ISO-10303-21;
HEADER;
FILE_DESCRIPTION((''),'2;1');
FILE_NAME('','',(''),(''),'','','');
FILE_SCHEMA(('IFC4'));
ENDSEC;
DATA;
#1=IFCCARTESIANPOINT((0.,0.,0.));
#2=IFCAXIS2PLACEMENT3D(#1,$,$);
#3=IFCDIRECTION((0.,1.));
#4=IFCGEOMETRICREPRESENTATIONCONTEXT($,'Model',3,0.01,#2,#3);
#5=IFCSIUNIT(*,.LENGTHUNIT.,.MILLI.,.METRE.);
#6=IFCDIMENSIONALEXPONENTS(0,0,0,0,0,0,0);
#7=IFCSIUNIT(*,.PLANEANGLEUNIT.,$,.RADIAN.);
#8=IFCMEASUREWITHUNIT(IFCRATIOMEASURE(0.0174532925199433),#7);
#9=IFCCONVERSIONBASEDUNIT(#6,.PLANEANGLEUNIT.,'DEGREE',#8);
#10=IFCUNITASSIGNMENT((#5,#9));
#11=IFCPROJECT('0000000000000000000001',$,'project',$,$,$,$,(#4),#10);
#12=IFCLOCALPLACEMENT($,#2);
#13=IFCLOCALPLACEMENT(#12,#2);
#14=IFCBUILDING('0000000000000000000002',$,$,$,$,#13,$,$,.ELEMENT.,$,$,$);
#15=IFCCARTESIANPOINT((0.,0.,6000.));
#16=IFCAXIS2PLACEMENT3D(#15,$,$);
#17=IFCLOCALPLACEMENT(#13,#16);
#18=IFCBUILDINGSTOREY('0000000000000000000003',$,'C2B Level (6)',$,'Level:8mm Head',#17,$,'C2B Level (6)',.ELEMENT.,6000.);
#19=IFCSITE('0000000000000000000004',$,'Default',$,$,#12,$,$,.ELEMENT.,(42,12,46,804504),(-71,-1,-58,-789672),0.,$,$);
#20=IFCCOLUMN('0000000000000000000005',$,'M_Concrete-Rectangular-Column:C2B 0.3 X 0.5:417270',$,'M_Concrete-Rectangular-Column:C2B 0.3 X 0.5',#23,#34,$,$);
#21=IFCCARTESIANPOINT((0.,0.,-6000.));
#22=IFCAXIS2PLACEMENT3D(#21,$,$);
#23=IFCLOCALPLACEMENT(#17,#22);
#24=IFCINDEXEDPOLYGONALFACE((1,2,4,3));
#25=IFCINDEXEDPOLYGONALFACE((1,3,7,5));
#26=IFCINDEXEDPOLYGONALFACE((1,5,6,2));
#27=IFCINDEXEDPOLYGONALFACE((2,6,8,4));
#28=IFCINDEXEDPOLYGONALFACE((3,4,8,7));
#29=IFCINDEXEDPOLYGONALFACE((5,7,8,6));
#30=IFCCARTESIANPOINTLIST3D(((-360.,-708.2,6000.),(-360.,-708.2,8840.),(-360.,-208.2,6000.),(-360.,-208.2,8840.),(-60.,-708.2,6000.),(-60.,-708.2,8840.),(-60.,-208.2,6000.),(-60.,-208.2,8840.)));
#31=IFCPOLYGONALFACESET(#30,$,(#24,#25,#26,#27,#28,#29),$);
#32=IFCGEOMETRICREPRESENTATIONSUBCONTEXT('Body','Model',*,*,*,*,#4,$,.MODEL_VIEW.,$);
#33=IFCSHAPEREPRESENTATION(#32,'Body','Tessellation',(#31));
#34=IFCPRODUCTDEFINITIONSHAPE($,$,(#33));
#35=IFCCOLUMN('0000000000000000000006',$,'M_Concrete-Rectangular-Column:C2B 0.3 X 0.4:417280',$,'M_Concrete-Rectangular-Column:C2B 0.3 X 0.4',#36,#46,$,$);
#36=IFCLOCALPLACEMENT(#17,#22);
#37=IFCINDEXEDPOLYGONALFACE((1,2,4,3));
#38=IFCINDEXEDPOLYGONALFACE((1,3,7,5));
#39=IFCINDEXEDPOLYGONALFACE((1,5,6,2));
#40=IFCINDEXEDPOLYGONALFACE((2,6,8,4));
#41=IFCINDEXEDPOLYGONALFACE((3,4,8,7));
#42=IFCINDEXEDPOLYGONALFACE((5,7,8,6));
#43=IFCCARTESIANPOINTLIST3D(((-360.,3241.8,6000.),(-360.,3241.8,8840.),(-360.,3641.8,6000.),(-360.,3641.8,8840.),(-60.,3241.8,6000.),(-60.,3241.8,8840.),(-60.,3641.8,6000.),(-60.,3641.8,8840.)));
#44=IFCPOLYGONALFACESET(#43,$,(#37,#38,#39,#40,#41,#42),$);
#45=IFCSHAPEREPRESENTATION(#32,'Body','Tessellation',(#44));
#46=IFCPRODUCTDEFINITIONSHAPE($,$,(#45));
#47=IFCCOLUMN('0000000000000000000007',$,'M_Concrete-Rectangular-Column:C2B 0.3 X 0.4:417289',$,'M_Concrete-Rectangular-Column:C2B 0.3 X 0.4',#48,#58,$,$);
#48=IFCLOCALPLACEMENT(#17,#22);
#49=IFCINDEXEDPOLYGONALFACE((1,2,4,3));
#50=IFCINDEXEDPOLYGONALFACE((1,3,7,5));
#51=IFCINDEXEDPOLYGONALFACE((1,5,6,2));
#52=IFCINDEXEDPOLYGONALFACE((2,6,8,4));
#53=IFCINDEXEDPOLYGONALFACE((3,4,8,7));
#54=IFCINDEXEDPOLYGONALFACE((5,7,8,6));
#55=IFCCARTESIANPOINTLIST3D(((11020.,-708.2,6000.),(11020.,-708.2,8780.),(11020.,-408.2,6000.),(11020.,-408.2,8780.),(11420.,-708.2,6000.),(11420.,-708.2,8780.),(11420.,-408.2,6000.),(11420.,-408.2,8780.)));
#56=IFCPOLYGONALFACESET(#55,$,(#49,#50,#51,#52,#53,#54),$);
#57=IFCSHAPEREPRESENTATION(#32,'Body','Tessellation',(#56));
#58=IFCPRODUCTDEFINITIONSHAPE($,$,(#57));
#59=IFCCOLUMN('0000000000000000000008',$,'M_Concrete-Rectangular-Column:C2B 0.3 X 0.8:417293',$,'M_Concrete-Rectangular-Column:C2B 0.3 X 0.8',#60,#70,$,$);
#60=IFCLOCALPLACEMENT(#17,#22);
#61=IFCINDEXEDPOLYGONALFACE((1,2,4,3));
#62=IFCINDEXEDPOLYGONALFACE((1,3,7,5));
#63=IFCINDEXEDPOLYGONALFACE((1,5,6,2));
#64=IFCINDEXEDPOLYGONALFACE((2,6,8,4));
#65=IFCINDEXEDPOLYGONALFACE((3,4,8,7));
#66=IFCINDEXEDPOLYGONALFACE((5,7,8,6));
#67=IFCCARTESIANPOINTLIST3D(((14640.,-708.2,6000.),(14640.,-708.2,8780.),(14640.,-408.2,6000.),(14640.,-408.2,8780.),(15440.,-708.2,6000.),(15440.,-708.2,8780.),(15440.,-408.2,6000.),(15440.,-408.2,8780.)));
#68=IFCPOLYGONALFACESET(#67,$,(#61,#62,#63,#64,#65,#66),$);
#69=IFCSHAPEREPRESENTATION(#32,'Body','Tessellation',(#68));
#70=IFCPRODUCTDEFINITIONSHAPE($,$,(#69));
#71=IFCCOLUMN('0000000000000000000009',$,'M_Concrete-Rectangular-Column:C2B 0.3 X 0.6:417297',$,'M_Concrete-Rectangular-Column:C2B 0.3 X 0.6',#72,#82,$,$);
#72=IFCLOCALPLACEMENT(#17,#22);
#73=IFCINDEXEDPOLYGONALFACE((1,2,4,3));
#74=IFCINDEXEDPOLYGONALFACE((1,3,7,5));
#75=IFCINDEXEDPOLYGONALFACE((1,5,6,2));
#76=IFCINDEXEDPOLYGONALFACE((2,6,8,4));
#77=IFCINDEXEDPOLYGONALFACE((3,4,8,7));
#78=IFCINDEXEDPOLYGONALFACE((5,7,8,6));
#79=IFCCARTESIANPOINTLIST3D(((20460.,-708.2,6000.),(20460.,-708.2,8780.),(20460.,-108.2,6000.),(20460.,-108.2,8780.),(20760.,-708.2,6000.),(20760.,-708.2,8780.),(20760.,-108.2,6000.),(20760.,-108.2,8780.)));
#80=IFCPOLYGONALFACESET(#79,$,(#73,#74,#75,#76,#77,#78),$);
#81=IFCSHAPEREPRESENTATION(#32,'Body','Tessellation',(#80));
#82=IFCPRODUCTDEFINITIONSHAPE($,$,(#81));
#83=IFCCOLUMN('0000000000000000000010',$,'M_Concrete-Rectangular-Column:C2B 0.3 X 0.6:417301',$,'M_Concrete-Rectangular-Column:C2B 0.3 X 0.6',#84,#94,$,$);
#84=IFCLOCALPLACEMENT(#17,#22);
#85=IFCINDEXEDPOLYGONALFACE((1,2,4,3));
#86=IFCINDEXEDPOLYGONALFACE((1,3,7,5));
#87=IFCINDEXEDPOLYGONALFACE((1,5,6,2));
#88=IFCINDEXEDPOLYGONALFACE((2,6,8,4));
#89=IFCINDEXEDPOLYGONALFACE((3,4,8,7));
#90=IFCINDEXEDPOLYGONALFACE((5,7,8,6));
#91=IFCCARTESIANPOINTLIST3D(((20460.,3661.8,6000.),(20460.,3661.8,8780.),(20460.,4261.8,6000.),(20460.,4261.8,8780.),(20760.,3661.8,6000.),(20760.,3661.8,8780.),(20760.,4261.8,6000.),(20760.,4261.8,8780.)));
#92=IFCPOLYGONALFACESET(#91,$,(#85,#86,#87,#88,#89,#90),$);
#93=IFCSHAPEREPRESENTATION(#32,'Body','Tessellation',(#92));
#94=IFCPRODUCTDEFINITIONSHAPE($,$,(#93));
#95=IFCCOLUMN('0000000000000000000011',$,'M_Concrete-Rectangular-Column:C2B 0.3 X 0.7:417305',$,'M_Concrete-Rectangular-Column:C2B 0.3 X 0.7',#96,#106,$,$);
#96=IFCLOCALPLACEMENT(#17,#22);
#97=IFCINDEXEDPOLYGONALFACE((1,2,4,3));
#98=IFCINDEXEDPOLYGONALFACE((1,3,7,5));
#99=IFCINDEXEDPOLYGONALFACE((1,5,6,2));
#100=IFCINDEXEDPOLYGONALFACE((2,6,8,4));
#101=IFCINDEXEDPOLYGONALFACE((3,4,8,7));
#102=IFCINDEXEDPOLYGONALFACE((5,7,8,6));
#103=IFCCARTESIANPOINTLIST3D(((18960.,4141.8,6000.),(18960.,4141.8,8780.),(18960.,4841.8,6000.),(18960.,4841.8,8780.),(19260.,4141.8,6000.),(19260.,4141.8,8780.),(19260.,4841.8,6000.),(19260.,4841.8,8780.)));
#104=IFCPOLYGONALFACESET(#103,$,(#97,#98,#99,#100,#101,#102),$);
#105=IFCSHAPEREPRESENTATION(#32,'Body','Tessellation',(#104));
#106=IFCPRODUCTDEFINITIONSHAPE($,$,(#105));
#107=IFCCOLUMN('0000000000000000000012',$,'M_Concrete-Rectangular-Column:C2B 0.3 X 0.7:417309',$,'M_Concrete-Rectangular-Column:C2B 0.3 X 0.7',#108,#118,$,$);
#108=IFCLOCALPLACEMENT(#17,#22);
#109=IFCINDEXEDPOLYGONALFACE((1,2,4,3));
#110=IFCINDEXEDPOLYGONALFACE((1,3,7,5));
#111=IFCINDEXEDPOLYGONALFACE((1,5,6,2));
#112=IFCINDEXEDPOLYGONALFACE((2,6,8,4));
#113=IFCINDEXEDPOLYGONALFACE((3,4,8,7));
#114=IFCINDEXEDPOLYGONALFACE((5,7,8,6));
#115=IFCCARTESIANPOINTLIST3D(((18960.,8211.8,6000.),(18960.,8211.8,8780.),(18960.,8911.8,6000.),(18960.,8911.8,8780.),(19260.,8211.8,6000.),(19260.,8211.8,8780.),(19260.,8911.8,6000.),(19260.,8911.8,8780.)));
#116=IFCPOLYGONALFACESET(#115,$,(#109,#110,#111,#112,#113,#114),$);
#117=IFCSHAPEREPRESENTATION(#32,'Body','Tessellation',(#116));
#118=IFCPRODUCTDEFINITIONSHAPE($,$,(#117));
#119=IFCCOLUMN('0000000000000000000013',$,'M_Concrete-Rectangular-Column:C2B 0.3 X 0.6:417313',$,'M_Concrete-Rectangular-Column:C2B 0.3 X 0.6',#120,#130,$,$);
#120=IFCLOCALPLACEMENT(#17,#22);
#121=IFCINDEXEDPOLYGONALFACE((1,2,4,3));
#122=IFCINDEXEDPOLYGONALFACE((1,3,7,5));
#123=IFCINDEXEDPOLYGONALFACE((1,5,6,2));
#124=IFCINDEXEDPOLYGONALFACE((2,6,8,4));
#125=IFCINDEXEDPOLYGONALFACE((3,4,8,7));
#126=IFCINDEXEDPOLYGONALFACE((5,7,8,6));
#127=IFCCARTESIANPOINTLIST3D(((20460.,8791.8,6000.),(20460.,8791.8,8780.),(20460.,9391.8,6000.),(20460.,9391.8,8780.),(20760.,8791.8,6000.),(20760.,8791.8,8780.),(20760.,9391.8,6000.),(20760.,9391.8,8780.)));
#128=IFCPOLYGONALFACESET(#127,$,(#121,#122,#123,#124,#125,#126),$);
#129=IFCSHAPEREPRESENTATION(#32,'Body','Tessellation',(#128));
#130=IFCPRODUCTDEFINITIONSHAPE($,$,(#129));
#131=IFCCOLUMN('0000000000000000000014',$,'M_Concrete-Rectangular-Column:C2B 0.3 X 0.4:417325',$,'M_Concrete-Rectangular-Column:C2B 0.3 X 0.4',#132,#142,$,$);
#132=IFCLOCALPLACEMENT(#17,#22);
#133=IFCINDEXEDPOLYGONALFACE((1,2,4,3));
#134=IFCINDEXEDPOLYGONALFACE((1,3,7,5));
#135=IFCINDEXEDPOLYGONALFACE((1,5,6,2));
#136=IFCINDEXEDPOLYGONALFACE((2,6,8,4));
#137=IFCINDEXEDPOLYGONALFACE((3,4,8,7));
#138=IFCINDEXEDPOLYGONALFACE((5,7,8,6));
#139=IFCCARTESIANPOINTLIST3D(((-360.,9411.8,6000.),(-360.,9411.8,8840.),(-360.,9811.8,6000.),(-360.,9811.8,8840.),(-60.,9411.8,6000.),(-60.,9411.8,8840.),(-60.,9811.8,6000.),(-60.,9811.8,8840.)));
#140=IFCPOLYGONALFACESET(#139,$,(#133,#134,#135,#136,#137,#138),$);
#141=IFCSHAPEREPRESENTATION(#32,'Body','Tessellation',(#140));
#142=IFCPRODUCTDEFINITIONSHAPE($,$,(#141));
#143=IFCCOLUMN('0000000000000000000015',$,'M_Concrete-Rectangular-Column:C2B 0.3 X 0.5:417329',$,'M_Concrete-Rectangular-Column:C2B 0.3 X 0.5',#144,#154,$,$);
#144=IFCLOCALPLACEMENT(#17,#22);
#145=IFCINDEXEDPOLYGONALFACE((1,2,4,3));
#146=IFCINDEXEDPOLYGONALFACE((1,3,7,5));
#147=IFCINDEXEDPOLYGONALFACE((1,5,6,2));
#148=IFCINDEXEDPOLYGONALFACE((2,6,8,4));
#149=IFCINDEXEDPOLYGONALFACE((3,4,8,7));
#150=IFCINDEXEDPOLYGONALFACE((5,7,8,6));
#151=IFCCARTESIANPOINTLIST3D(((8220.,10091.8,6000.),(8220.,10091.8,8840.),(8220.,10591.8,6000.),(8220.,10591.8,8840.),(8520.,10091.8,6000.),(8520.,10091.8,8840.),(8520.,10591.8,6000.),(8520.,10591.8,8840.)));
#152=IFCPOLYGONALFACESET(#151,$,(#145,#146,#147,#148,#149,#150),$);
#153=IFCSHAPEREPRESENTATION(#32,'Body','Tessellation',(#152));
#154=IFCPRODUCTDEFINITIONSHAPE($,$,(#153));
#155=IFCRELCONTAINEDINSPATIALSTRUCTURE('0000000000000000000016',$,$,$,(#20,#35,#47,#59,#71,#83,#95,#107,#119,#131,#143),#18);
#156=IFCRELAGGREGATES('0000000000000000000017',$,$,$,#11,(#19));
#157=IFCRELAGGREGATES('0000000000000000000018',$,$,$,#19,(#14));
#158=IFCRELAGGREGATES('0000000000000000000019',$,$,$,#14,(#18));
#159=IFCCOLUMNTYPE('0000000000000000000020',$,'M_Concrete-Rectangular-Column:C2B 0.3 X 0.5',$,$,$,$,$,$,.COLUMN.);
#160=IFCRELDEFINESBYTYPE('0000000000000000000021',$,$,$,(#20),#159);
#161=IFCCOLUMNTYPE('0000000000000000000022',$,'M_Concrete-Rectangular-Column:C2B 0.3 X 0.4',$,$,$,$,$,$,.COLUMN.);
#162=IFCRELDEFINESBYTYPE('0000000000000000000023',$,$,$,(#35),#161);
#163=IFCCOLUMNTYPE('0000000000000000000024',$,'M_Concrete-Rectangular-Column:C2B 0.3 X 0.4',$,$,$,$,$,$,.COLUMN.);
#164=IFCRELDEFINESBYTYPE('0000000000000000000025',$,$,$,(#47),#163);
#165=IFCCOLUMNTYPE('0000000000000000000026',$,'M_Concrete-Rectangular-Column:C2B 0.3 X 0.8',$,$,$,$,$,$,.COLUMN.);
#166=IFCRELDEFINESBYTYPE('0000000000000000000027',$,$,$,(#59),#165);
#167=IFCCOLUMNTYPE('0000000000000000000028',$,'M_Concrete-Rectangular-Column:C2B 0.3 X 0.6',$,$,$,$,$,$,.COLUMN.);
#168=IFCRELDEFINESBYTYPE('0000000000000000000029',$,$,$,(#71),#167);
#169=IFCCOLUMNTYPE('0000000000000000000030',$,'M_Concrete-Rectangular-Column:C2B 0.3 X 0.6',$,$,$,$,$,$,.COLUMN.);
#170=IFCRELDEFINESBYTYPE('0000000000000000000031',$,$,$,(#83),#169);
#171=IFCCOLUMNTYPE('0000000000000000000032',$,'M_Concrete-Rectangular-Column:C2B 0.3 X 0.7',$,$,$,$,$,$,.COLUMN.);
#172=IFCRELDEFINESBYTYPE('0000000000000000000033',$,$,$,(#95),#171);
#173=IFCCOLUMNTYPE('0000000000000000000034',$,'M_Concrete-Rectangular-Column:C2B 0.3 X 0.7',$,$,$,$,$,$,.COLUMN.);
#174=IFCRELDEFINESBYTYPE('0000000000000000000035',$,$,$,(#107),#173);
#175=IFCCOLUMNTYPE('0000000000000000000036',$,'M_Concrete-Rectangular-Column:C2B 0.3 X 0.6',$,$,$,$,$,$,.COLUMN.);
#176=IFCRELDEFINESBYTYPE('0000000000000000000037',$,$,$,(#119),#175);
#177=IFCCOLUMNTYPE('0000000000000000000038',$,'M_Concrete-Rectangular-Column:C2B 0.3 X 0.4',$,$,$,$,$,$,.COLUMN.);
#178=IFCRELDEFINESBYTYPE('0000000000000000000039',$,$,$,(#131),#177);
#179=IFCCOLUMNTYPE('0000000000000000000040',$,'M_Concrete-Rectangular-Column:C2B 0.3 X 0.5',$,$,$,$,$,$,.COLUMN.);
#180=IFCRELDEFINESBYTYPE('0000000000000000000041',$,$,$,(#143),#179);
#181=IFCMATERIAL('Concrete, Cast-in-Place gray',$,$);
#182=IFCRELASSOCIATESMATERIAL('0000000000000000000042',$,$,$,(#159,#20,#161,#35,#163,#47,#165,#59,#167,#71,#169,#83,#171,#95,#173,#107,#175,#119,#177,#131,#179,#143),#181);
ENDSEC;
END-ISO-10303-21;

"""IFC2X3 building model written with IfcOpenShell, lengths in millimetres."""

from ifc_helpers import new_model, entity, si_unit, converted_unit, direction, frame, frame_2d, origin, origin_2d_with_axis, place, context, subcontext, project, spatial, rectangle, extrude, source, transform, mapped, material, type_object, type_shapes, element, save


model = new_model("IFC2X3")

# Units and contexts
model_context = context("Model", 3, precision=0.01, world=origin(), true_north=direction((0.0, 1.0)))
body_context = subcontext(model_context, "Body", "Model", "MODEL_VIEW")
ifc_project = project(units=[si_unit("LENGTHUNIT", "METRE", prefix="MILLI"), converted_unit("PLANEANGLEUNIT", "DEGREE", entity("IfcRatioMeasure", 0.0174532925199433), si_unit("PLANEANGLEUNIT", "RADIAN"), dimensions=[0, 0, 0, 0, 0, 0, 0])], contexts=[model_context])

# Site, building, storey
site_placement = place(None, origin())
site = spatial("IfcSite", under=ifc_project, at=site_placement, Name="Default", CompositionType="ELEMENT", RefLatitude=(42, 12, 46, 804504), RefLongitude=(-71, -1, -58, -789672), RefElevation=0.0)
building_placement = place(site_placement, origin())
building = spatial("IfcBuilding", under=site, at=building_placement, CompositionType="ELEMENT")
storey_placement = place(building_placement, frame((0.0, 0.0, 6000.0)))
storey = spatial("IfcBuildingStorey", under=building, at=storey_placement, Name="C2B Level (6)", ObjectType="Level:8mm Head", LongName="C2B Level (6)", CompositionType="ELEMENT", Elevation=6000.0)

# Columns
ifc_material = material(Name="Concrete, Cast-in-Place gray")
column_type_1 = type_object("IfcColumnType", Name="M_Concrete-Rectangular-Column:C2B 0.3 X 0.5", PredefinedType="COLUMN", material=ifc_material)
shared_shape_1 = source(origin(), body_context, "Body", "SweptSolid", [
    extrude(rectangle(XDim=500.0, YDim=300.0, at=frame_2d((0.0, 0.0), x_axis=(1.0, 0.0))), frame((-210.0, -458.2, 6000.0), z_axis=(0.0, 0.0, 1.0), x_axis=(0.0, -1.0, 0.0)), (0.0, 0.0, 1.0), 2840.0),
])
type_shapes(column_type_1, [shared_shape_1])
column_1_placement = place(storey_placement, frame((0.0, 0.0, -6000.0)))
element("IfcColumn", 1, at=column_1_placement, inside=storey, type_object=column_type_1, material=ifc_material, Name="M_Concrete-Rectangular-Column:C2B 0.3 X 0.5:417270", ObjectType="M_Concrete-Rectangular-Column:C2B 0.3 X 0.5", context=body_context, shape_type="MappedRepresentation", body=[
    mapped(shared_shape_1, transform((0.0, 0.0, 0.0), scale=1.0)),
])
column_type_2 = type_object("IfcColumnType", Name="M_Concrete-Rectangular-Column:C2B 0.3 X 0.4", PredefinedType="COLUMN", material=ifc_material)
shared_shape_2 = source(origin(), body_context, "Body", "SweptSolid", [
    extrude(rectangle(XDim=400.0, YDim=300.0, at=frame_2d((0.0, 0.0), x_axis=(1.0, 0.0))), frame((-210.0, 3441.8, 6000.0), z_axis=(0.0, 0.0, 1.0), x_axis=(0.0, -1.0, 0.0)), (0.0, 0.0, 1.0), 2840.0),
])
type_shapes(column_type_2, [shared_shape_2])
column_2_placement = place(storey_placement, frame((0.0, 0.0, -6000.0)))
element("IfcColumn", 2, at=column_2_placement, inside=storey, type_object=column_type_2, material=ifc_material, Name="M_Concrete-Rectangular-Column:C2B 0.3 X 0.4:417280", ObjectType="M_Concrete-Rectangular-Column:C2B 0.3 X 0.4", context=body_context, shape_type="MappedRepresentation", body=[
    mapped(shared_shape_2, transform((0.0, 0.0, 0.0), scale=1.0)),
])
column_type_3 = type_object("IfcColumnType", Name="M_Concrete-Rectangular-Column:C2B 0.3 X 0.4", PredefinedType="COLUMN", material=ifc_material)
shared_shape_3 = source(origin(), body_context, "Body", "SweptSolid", [
    extrude(rectangle(XDim=300.0, YDim=400.0, at=origin_2d_with_axis()), frame((11220.0, -558.2, 6000.0), z_axis=(0.0, 0.0, 1.0), x_axis=(0.0, -1.0, 0.0)), (0.0, 0.0, 1.0), 2780.0),
])
type_shapes(column_type_3, [shared_shape_3])
column_3_placement = place(storey_placement, frame((0.0, 0.0, -6000.0)))
element("IfcColumn", 3, at=column_3_placement, inside=storey, type_object=column_type_3, material=ifc_material, Name="M_Concrete-Rectangular-Column:C2B 0.3 X 0.4:417289", ObjectType="M_Concrete-Rectangular-Column:C2B 0.3 X 0.4", context=body_context, shape_type="MappedRepresentation", body=[
    mapped(shared_shape_3, transform((0.0, 0.0, 0.0), scale=1.0)),
])
column_type_4 = type_object("IfcColumnType", Name="M_Concrete-Rectangular-Column:C2B 0.3 X 0.8", PredefinedType="COLUMN", material=ifc_material)
shared_shape_4 = source(origin(), body_context, "Body", "SweptSolid", [
    extrude(rectangle(XDim=300.0, YDim=800.0, at=origin_2d_with_axis()), frame((15040.0, -558.2, 6000.0), z_axis=(0.0, 0.0, 1.0), x_axis=(0.0, -1.0, 0.0)), (0.0, 0.0, 1.0), 2780.0),
])
type_shapes(column_type_4, [shared_shape_4])
column_4_placement = place(storey_placement, frame((0.0, 0.0, -6000.0)))
element("IfcColumn", 4, at=column_4_placement, inside=storey, type_object=column_type_4, material=ifc_material, Name="M_Concrete-Rectangular-Column:C2B 0.3 X 0.8:417293", ObjectType="M_Concrete-Rectangular-Column:C2B 0.3 X 0.8", context=body_context, shape_type="MappedRepresentation", body=[
    mapped(shared_shape_4, transform((0.0, 0.0, 0.0), scale=1.0)),
])
column_type_5 = type_object("IfcColumnType", Name="M_Concrete-Rectangular-Column:C2B 0.3 X 0.6", PredefinedType="COLUMN", material=ifc_material)
shared_shape_5 = source(origin(), body_context, "Body", "SweptSolid", [
    extrude(rectangle(XDim=600.0, YDim=300.0, at=frame_2d((0.0, 0.0), x_axis=(1.0, 0.0))), frame((20610.0, -408.2, 6000.0), z_axis=(0.0, 0.0, 1.0), x_axis=(0.0, -1.0, 0.0)), (0.0, 0.0, 1.0), 2780.0),
])
type_shapes(column_type_5, [shared_shape_5])
column_5_placement = place(storey_placement, frame((0.0, 0.0, -6000.0)))
element("IfcColumn", 5, at=column_5_placement, inside=storey, type_object=column_type_5, material=ifc_material, Name="M_Concrete-Rectangular-Column:C2B 0.3 X 0.6:417297", ObjectType="M_Concrete-Rectangular-Column:C2B 0.3 X 0.6", context=body_context, shape_type="MappedRepresentation", body=[
    mapped(shared_shape_5, transform((0.0, 0.0, 0.0), scale=1.0)),
])
column_type_6 = type_object("IfcColumnType", Name="M_Concrete-Rectangular-Column:C2B 0.3 X 0.6", PredefinedType="COLUMN", material=ifc_material)
shared_shape_6 = source(origin(), body_context, "Body", "SweptSolid", [
    extrude(rectangle(XDim=600.0, YDim=300.0, at=origin_2d_with_axis()), frame((20610.0, 3961.8, 6000.0), z_axis=(0.0, 0.0, 1.0), x_axis=(0.0, -1.0, 0.0)), (0.0, 0.0, 1.0), 2780.0),
])
type_shapes(column_type_6, [shared_shape_6])
column_6_placement = place(storey_placement, frame((0.0, 0.0, -6000.0)))
element("IfcColumn", 6, at=column_6_placement, inside=storey, type_object=column_type_6, material=ifc_material, Name="M_Concrete-Rectangular-Column:C2B 0.3 X 0.6:417301", ObjectType="M_Concrete-Rectangular-Column:C2B 0.3 X 0.6", context=body_context, shape_type="MappedRepresentation", body=[
    mapped(shared_shape_6, transform((0.0, 0.0, 0.0), scale=1.0)),
])
column_type_7 = type_object("IfcColumnType", Name="M_Concrete-Rectangular-Column:C2B 0.3 X 0.7", PredefinedType="COLUMN", material=ifc_material)
shared_shape_7 = source(origin(), body_context, "Body", "SweptSolid", [
    extrude(rectangle(XDim=700.0, YDim=300.0, at=origin_2d_with_axis()), frame((19110.0, 4491.8, 6000.0), z_axis=(0.0, 0.0, 1.0), x_axis=(0.0, -1.0, 0.0)), (0.0, 0.0, 1.0), 2780.0),
])
type_shapes(column_type_7, [shared_shape_7])
column_7_placement = place(storey_placement, frame((0.0, 0.0, -6000.0)))
element("IfcColumn", 7, at=column_7_placement, inside=storey, type_object=column_type_7, material=ifc_material, Name="M_Concrete-Rectangular-Column:C2B 0.3 X 0.7:417305", ObjectType="M_Concrete-Rectangular-Column:C2B 0.3 X 0.7", context=body_context, shape_type="MappedRepresentation", body=[
    mapped(shared_shape_7, transform((0.0, 0.0, 0.0), scale=1.0)),
])
column_type_8 = type_object("IfcColumnType", Name="M_Concrete-Rectangular-Column:C2B 0.3 X 0.7", PredefinedType="COLUMN", material=ifc_material)
shared_shape_8 = source(origin(), body_context, "Body", "SweptSolid", [
    extrude(rectangle(XDim=700.0, YDim=300.0, at=origin_2d_with_axis()), frame((19110.0, 8561.8, 6000.0), z_axis=(0.0, 0.0, 1.0), x_axis=(0.0, -1.0, 0.0)), (0.0, 0.0, 1.0), 2780.0),
])
type_shapes(column_type_8, [shared_shape_8])
column_8_placement = place(storey_placement, frame((0.0, 0.0, -6000.0)))
element("IfcColumn", 8, at=column_8_placement, inside=storey, type_object=column_type_8, material=ifc_material, Name="M_Concrete-Rectangular-Column:C2B 0.3 X 0.7:417309", ObjectType="M_Concrete-Rectangular-Column:C2B 0.3 X 0.7", context=body_context, shape_type="MappedRepresentation", body=[
    mapped(shared_shape_8, transform((0.0, 0.0, 0.0), scale=1.0)),
])
column_type_9 = type_object("IfcColumnType", Name="M_Concrete-Rectangular-Column:C2B 0.3 X 0.6", PredefinedType="COLUMN", material=ifc_material)
shared_shape_9 = source(origin(), body_context, "Body", "SweptSolid", [
    extrude(rectangle(XDim=600.0, YDim=300.0, at=origin_2d_with_axis()), frame((20610.0, 9091.8, 6000.0), z_axis=(0.0, 0.0, 1.0), x_axis=(0.0, -1.0, 0.0)), (0.0, 0.0, 1.0), 2780.0),
])
type_shapes(column_type_9, [shared_shape_9])
column_9_placement = place(storey_placement, frame((0.0, 0.0, -6000.0)))
element("IfcColumn", 9, at=column_9_placement, inside=storey, type_object=column_type_9, material=ifc_material, Name="M_Concrete-Rectangular-Column:C2B 0.3 X 0.6:417313", ObjectType="M_Concrete-Rectangular-Column:C2B 0.3 X 0.6", context=body_context, shape_type="MappedRepresentation", body=[
    mapped(shared_shape_9, transform((0.0, 0.0, 0.0), scale=1.0)),
])
column_type_10 = type_object("IfcColumnType", Name="M_Concrete-Rectangular-Column:C2B 0.3 X 0.4", PredefinedType="COLUMN", material=ifc_material)
shared_shape_10 = source(origin(), body_context, "Body", "SweptSolid", [
    extrude(rectangle(XDim=400.0, YDim=300.0, at=frame_2d((0.0, 0.0), x_axis=(1.0, 0.0))), frame((-210.0, 9611.8, 6000.0), z_axis=(0.0, 0.0, 1.0), x_axis=(0.0, -1.0, 0.0)), (0.0, 0.0, 1.0), 2840.0),
])
type_shapes(column_type_10, [shared_shape_10])
column_10_placement = place(storey_placement, frame((0.0, 0.0, -6000.0)))
element("IfcColumn", 10, at=column_10_placement, inside=storey, type_object=column_type_10, material=ifc_material, Name="M_Concrete-Rectangular-Column:C2B 0.3 X 0.4:417325", ObjectType="M_Concrete-Rectangular-Column:C2B 0.3 X 0.4", context=body_context, shape_type="MappedRepresentation", body=[
    mapped(shared_shape_10, transform((0.0, 0.0, 0.0), scale=1.0)),
])
column_type_11 = type_object("IfcColumnType", Name="M_Concrete-Rectangular-Column:C2B 0.3 X 0.5", PredefinedType="COLUMN", material=ifc_material)
shared_shape_11 = source(origin(), body_context, "Body", "SweptSolid", [
    extrude(rectangle(XDim=500.0, YDim=300.0, at=frame_2d((0.0, 0.0), x_axis=(1.0, 0.0))), frame((8370.0, 10341.8, 6000.0), z_axis=(0.0, 0.0, 1.0), x_axis=(0.0, -1.0, 0.0)), (0.0, 0.0, 1.0), 2840.0),
])
type_shapes(column_type_11, [shared_shape_11])
column_11_placement = place(storey_placement, frame((0.0, 0.0, -6000.0)))
element("IfcColumn", 11, at=column_11_placement, inside=storey, type_object=column_type_11, material=ifc_material, Name="M_Concrete-Rectangular-Column:C2B 0.3 X 0.5:417329", ObjectType="M_Concrete-Rectangular-Column:C2B 0.3 X 0.5", context=body_context, shape_type="MappedRepresentation", body=[
    mapped(shared_shape_11, transform((0.0, 0.0, 0.0), scale=1.0)),
])

save(model, "model.ifc")
